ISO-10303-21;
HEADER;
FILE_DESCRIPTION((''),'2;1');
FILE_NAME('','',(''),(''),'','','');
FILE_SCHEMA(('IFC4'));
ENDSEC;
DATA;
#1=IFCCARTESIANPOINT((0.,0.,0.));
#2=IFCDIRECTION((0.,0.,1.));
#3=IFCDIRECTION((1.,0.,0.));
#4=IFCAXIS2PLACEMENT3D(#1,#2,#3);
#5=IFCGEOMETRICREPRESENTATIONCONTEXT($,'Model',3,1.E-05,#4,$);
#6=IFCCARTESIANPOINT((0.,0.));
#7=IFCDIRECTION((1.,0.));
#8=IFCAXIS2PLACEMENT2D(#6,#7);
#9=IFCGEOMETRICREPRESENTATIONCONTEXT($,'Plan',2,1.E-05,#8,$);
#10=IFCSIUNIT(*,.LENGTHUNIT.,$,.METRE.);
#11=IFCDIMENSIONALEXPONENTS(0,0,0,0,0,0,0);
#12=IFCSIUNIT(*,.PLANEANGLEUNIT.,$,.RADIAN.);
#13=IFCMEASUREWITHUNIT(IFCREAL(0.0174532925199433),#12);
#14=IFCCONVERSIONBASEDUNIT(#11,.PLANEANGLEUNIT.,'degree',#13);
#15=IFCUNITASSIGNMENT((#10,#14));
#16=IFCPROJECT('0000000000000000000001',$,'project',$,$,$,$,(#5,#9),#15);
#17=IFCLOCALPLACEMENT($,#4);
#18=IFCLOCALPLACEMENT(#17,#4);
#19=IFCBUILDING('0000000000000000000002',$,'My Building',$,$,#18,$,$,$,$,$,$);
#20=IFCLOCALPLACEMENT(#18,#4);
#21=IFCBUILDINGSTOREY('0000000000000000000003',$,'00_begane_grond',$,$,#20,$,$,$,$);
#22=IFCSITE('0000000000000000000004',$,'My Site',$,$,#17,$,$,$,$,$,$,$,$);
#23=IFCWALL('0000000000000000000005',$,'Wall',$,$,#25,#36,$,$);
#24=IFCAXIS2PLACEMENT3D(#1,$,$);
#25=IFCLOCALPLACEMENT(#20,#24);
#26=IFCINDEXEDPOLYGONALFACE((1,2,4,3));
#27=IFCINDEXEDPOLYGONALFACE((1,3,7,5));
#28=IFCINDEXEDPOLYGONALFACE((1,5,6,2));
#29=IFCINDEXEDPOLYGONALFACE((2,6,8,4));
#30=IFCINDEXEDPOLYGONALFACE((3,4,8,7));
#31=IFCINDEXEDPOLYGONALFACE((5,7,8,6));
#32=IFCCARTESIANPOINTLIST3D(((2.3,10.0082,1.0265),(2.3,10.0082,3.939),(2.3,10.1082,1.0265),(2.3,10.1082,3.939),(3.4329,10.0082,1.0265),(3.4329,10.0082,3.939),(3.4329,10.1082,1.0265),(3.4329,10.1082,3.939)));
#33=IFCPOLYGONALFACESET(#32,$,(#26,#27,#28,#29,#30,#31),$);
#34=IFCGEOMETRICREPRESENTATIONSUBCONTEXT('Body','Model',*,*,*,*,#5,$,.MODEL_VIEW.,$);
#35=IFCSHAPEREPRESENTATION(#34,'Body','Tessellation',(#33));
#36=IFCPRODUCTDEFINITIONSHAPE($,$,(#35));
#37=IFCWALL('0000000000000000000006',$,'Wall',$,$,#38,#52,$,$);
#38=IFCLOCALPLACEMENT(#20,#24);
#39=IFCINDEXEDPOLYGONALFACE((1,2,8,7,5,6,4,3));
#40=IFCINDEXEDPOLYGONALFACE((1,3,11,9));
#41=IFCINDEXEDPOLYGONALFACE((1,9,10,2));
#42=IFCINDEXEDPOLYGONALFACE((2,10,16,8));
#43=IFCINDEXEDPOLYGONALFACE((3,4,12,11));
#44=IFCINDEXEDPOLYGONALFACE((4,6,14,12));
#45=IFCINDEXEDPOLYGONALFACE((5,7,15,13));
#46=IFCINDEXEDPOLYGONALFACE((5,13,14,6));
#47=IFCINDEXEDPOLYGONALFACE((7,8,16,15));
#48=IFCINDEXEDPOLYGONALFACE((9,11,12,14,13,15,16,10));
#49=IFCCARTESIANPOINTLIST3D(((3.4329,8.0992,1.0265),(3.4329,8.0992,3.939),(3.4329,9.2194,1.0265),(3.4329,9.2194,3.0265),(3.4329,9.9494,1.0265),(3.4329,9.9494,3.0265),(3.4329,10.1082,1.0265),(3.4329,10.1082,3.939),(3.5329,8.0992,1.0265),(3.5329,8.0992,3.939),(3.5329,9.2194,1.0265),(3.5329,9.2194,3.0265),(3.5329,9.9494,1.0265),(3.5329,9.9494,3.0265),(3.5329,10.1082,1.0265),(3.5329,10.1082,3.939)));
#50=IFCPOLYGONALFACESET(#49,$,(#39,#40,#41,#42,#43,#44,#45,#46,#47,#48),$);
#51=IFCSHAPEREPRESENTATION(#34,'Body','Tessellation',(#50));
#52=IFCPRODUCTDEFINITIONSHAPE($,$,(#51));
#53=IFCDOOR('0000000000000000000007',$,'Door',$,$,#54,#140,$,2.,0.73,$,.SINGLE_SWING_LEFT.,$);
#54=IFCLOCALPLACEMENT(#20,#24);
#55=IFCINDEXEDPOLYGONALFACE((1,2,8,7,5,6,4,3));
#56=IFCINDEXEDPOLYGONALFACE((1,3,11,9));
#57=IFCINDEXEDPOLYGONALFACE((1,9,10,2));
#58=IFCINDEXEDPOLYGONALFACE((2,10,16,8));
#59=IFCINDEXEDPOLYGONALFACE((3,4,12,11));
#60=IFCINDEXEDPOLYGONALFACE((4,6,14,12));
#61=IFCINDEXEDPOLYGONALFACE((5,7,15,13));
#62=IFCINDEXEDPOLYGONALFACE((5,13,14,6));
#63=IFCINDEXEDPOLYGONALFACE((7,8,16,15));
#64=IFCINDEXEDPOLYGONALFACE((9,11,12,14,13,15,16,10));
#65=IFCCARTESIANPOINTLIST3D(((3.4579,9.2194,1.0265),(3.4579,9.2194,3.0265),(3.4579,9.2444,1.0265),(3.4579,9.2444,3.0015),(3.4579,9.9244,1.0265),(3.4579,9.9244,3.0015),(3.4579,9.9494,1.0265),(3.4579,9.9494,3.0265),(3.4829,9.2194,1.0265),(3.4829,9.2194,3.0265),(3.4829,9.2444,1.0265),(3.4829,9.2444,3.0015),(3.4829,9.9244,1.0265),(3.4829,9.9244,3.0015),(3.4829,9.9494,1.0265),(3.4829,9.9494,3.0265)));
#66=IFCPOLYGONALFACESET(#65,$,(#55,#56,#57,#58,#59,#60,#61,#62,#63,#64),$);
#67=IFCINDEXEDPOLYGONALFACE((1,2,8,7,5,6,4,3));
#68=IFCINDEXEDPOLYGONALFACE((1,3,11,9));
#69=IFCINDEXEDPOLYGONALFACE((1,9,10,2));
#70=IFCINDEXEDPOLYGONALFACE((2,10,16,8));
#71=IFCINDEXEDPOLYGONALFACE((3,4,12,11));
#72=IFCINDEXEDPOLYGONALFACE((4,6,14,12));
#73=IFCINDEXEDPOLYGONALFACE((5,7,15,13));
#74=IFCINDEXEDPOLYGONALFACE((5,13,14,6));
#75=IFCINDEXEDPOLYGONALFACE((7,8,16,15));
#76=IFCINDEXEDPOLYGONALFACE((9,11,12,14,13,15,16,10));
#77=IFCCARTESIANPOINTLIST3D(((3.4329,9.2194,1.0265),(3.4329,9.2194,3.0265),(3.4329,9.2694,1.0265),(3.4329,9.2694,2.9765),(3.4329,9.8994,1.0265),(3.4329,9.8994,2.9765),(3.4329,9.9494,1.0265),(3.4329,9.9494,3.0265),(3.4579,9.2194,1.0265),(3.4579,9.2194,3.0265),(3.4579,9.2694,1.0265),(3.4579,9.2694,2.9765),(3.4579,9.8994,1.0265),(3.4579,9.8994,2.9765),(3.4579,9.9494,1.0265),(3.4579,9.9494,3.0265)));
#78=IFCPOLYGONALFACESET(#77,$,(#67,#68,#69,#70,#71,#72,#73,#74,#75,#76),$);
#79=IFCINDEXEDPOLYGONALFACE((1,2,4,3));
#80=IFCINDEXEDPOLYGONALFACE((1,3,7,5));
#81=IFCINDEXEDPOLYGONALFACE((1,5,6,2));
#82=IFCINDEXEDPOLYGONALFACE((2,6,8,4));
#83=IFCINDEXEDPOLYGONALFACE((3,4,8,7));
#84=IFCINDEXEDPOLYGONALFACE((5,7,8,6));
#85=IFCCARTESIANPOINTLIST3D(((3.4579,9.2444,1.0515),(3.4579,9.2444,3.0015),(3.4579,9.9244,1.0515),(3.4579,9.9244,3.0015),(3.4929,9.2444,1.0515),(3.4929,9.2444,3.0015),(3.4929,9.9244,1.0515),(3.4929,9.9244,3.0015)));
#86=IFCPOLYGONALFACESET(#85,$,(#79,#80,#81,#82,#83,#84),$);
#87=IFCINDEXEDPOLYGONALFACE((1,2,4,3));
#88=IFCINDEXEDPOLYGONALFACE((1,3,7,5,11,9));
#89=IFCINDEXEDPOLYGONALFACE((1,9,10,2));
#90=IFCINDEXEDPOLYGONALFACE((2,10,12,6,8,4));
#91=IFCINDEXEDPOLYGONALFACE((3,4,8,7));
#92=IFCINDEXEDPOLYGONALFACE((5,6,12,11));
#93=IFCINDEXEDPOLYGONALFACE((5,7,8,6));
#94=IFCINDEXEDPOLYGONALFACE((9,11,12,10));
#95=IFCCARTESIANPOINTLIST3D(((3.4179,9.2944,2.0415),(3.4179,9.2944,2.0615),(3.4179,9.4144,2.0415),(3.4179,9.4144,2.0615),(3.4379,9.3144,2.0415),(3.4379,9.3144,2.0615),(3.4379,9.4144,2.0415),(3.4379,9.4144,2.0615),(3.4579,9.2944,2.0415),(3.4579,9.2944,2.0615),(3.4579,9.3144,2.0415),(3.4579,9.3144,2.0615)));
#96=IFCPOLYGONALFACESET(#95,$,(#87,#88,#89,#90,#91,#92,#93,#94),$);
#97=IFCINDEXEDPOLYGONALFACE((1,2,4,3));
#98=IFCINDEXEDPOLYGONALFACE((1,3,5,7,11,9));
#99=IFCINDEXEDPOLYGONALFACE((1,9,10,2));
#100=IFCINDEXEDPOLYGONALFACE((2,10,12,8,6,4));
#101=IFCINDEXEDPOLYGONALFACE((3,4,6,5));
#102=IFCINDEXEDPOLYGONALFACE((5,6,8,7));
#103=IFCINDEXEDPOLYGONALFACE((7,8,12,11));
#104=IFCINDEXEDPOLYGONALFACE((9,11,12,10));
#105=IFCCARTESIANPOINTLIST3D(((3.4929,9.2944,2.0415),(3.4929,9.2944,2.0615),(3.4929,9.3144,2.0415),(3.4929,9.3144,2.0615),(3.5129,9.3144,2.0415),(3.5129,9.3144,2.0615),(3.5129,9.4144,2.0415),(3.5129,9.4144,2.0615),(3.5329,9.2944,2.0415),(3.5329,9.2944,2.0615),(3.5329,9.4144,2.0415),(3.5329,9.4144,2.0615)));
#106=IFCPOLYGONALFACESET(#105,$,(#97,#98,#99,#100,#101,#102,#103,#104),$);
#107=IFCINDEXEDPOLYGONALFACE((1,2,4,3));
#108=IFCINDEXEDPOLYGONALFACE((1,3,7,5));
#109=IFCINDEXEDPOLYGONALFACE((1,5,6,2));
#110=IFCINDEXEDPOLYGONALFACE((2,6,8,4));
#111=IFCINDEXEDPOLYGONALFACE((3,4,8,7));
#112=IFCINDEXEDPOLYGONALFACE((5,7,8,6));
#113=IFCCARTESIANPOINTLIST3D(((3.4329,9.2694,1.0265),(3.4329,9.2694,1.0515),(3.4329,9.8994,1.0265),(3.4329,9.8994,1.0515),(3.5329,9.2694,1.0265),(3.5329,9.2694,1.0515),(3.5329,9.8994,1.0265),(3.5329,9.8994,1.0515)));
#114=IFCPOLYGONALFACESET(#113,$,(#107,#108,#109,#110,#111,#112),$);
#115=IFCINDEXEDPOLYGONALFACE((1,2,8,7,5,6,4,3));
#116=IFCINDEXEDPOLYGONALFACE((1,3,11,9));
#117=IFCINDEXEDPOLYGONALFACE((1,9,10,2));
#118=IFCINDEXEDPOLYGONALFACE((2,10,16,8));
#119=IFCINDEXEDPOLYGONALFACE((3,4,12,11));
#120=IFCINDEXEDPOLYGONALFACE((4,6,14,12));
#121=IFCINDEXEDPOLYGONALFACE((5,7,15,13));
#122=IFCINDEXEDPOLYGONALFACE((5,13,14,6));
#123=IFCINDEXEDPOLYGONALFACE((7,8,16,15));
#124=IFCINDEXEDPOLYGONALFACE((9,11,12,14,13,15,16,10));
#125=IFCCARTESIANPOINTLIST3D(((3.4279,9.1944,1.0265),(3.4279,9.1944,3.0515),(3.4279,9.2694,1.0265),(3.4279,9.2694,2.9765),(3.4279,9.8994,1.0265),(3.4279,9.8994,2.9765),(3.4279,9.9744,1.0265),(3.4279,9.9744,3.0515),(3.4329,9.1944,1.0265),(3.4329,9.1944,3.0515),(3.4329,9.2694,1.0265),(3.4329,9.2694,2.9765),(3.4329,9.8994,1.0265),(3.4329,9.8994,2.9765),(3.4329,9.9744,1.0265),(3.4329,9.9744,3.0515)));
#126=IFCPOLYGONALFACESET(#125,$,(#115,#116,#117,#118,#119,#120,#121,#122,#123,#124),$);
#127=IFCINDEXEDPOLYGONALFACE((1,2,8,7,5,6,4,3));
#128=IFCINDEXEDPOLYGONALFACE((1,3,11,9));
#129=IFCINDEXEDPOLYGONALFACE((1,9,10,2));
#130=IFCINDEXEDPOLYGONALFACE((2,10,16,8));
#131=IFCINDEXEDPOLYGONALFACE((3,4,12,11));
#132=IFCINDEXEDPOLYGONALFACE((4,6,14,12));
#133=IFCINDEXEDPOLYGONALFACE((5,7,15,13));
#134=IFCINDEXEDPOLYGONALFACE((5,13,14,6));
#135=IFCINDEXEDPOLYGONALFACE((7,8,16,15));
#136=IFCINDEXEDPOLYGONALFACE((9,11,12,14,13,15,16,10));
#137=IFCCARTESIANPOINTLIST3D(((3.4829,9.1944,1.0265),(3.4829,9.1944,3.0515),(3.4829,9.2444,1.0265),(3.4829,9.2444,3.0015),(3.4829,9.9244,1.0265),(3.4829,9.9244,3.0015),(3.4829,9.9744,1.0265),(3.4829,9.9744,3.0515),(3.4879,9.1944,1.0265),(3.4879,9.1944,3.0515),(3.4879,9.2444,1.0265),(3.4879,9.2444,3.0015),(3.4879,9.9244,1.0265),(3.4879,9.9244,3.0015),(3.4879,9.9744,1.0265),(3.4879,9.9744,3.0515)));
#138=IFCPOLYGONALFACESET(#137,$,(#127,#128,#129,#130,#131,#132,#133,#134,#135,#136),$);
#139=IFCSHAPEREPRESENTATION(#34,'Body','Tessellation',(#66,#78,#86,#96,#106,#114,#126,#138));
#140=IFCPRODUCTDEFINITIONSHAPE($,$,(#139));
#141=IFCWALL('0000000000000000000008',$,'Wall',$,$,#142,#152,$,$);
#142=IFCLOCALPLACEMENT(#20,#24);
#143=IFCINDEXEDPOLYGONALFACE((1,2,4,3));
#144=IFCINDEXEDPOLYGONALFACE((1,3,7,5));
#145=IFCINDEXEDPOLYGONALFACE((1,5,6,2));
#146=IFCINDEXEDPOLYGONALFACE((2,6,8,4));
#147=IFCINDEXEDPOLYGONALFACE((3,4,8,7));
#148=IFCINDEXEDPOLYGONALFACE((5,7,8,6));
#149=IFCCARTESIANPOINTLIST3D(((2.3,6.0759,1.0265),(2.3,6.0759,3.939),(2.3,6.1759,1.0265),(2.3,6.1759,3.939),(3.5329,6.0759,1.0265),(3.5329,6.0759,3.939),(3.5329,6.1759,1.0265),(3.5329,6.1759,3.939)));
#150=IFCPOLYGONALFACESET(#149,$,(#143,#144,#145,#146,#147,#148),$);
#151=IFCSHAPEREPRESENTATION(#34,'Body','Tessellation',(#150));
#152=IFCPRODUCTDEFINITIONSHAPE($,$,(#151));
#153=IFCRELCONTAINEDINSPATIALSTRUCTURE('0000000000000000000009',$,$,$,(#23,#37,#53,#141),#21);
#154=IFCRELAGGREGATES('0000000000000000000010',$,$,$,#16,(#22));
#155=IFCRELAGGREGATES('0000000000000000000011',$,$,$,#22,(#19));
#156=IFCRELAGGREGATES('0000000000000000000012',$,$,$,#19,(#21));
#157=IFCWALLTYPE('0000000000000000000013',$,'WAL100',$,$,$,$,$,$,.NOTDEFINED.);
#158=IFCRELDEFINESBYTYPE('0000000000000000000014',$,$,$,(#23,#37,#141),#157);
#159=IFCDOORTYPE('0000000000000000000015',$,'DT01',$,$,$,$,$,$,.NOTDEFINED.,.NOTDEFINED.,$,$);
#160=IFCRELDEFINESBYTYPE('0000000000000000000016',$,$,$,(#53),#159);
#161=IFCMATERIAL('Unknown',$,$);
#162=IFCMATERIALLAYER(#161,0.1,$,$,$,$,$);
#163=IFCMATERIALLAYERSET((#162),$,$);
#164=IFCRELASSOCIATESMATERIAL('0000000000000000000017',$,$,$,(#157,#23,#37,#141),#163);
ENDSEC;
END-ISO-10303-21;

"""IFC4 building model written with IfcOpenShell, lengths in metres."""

from ifc_helpers import new_model, entity, si_unit, converted_unit, frame, origin_with_axes, origin_2d_with_axis, place, context, subcontext, project, spatial, line, indexed_curve, outline, extrude, shape, source, transform, mapped, material, layer, layer_set, layer_usage, type_object, type_shapes, element, fill, save


model = new_model("IFC4")

# Units and contexts
model_context = context("Model", 3, precision=1e-05, world=origin_with_axes())
plan_context = context("Plan", 2, precision=1e-05, world=origin_2d_with_axis())
body_context_1 = subcontext(model_context, "Body", "Model", "MODEL_VIEW")
body_context_2 = subcontext(plan_context, "Body", "Plan", "PLAN_VIEW")
ifc_project = project(units=[si_unit("LENGTHUNIT", "METRE"), converted_unit("PLANEANGLEUNIT", "degree", entity("IfcReal", 0.0174532925199433), si_unit("PLANEANGLEUNIT", "RADIAN"), dimensions=[0, 0, 0, 0, 0, 0, 0])], contexts=[model_context, plan_context])

# Site, building, storey
site_placement = place(None, origin_with_axes())
site = spatial("IfcSite", under=ifc_project, at=site_placement, Name="My Site")
building_placement = place(site_placement, origin_with_axes())
building = spatial("IfcBuilding", under=site, at=building_placement, Name="My Building")
storey_placement = place(building_placement, origin_with_axes())
storey = spatial("IfcBuildingStorey", under=building, at=storey_placement, Name="00_begane_grond")

# Shared definitions
ifc_material = material(Name="Unknown")

# Shared definitions
ifc_layer_1 = layer(ifc_material, 0.1)
ifc_layer_set_1 = layer_set([ifc_layer_1])
wall_type_1 = type_object("IfcWallType", Name="WAL100", PredefinedType="NOTDEFINED", material=ifc_layer_set_1)

# Shared definitions
shared_shape_1 = source(origin_with_axes(), body_context_1, "Body", "SweptSolid", [
    extrude(outline(indexed_curve([(0.0, 0.0), (0.73, 0.0), (0.73, 2.0), (0.0, 2.0)], segments=[line(1, 2, 3, 4, 1)])), frame((0.0, -0.1, 0.0), z_axis=(0.0, -1.0, 0.0), x_axis=(1.0, 0.0, 0.0)), (0.0, 0.0, -1.0), 0.3),
])
door_type_1 = type_object("IfcDoorType", Name="DT01", OperationType="NOTDEFINED", PredefinedType="NOTDEFINED")
shared_shape_2 = source(origin_with_axes(), body_context_1, "Body", "SweptSolid", [
    extrude(outline(indexed_curve([(0.0, 0.0), (0.0, 2.0), (0.73, 2.0), (0.73, 0.0), (0.705, 0.0), (0.705, 1.975), (0.025, 1.975), (0.025, 0.0)], segments=[line(1, 2, 3, 4, 5, 6, 7, 8, 1)])), frame((0.0, 0.025, 0.0), z_axis=(0.0, -1.0, 0.0), x_axis=(1.0, 0.0, 0.0)), (0.0, 0.0, -1.0), 0.025),
    extrude(outline(indexed_curve([(0.0, 0.0), (0.0, 2.0), (0.73, 2.0), (0.73, 0.0), (0.68, 0.0), (0.68, 1.95), (0.05, 1.95), (0.05, 0.0)], segments=[line(1, 2, 3, 4, 5, 6, 7, 8, 1)])), frame((0.0, 0.0, 0.0), z_axis=(0.0, -1.0, 0.0), x_axis=(1.0, 0.0, 0.0)), (0.0, 0.0, -1.0), 0.025),
    extrude(outline(indexed_curve([(0.0, 0.0), (0.68, 0.0), (0.68, 0.035), (0.0, 0.035)], segments=[line(1, 2, 3, 4, 1)])), frame((0.025, 0.025, 0.025), z_axis=(0.0, 0.0, 1.0), x_axis=(1.0, 0.0, 0.0)), (0.0, 0.0, 1.0), 1.95),
    extrude(outline(indexed_curve([(0.0, 0.0), (0.0, -0.04), (-0.12, -0.04), (-0.12, -0.02), (-0.02, -0.02), (-0.02, 0.0)], segments=[line(1, 2, 3, 4, 5, 6, 1)])), frame((0.655, 0.025, 1.015), z_axis=(0.0, 0.0, 1.0), x_axis=(1.0, 0.0, 0.0)), (0.0, 0.0, 1.0), 0.02),
    extrude(outline(indexed_curve([(0.0, 0.0), (0.0, 0.04), (-0.12, 0.04), (-0.12, 0.02), (-0.02, 0.02), (-0.02, 0.0)], segments=[line(1, 2, 3, 4, 5, 6, 1)])), frame((0.655, 0.06, 1.015), z_axis=(0.0, 0.0, 1.0), x_axis=(1.0, 0.0, 0.0)), (0.0, 0.0, 1.0), 0.02),
    extrude(outline(indexed_curve([(0.0, 0.0), (0.63, 0.0), (0.63, 0.1), (0.0, 0.1)], segments=[line(1, 2, 3, 4, 1)])), frame((0.05, 0.0, 0.0), z_axis=(0.0, 0.0, 1.0), x_axis=(1.0, 0.0, 0.0)), (0.0, 0.0, 1.0), 0.025),
    extrude(outline(indexed_curve([(0.0, 0.0), (0.0, 2.025), (0.78, 2.025), (0.78, 0.0), (0.705, 0.0), (0.705, 1.95), (0.075, 1.95), (0.075, 0.0)], segments=[line(1, 2, 3, 4, 5, 6, 7, 8, 1)])), frame((-0.025, -0.005, 0.0), z_axis=(0.0, -1.0, 0.0), x_axis=(1.0, 0.0, 0.0)), (0.0, 0.0, -1.0), 0.005),
    extrude(outline(indexed_curve([(0.0, 0.0), (0.0, 2.025), (0.78, 2.025), (0.78, 0.0), (0.73, 0.0), (0.73, 1.975), (0.05, 1.975), (0.05, 0.0)], segments=[line(1, 2, 3, 4, 5, 6, 7, 8, 1)])), frame((-0.025, 0.05, 0.0), z_axis=(0.0, -1.0, 0.0), x_axis=(1.0, 0.0, 0.0)), (0.0, 0.0, -1.0), 0.005),
])
shared_shape_3 = source(origin_with_axes(), body_context_2, "Body", "Curve2D", [
    entity("IfcIndexedPolyCurve", entity("IfcCartesianPointList2D", [[0.0, 0.0], [0.0, 0.05], [0.025, 0.05], [0.025, 0.025], [0.05, 0.025], [0.05, 0.0]]), [entity("IfcLineIndex", [1, 2, 3, 4, 5, 6, 1])]),
    entity("IfcIndexedPolyCurve", entity("IfcCartesianPointList2D", [[0.73, 0.0], [0.73, 0.05], [0.705, 0.05], [0.705, 0.025], [0.68, 0.025], [0.68, 0.0]]), [entity("IfcLineIndex", [1, 2, 3, 4, 5, 6, 1])]),
    entity("IfcTrimmedCurve", entity("IfcEllipse", entity("IfcAxis2Placement2D", entity("IfcCartesianPoint", [0.06, 0.05]), entity("IfcDirection", [1.0, 0.0])), 0.645, 0.68), [entity("IfcCartesianPoint", [0.705, 0.05])], [entity("IfcCartesianPoint", [0.06, 0.73])], True, "CARTESIAN"),
    entity("IfcIndexedPolyCurve", entity("IfcCartesianPointList2D", [[0.025, 0.05], [0.06, 0.05], [0.06, 0.73], [0.025, 0.73]]), [entity("IfcLineIndex", [1, 2, 3, 4, 1])]),
])
type_shapes(door_type_1, [shared_shape_2, shared_shape_3])

# Wall
ifc_layer_usage_1 = layer_usage(ifc_layer_set_1, "AXIS2", "POSITIVE", 0.0)
wall_1_placement = place(storey_placement, frame((2.3, 10.0082, 1.0265), z_axis=(0.0, 0.0, 1.0), x_axis=(1.0, -0.000001, 0.0)))
element("IfcWall", 1, at=wall_1_placement, inside=storey, type_object=wall_type_1, material=ifc_layer_usage_1, Name="Wall", context=body_context_1, shape_type="SweptSolid", body=[
    extrude(outline(indexed_curve([(0.0, 0.0), (0.0, 0.1), (1.1329, 0.1), (1.1329, 0.0), (0.0, 0.0)], self_intersect=False)), origin_with_axes(), (0.0, 0.0, 1.0), 2.9125),
])

# Wall, opening, door
ifc_layer_usage_2 = layer_usage(ifc_layer_set_1, "AXIS2", "POSITIVE", 0.0)
wall_2_placement = place(storey_placement, frame((3.5329, 8.0992, 1.0265), z_axis=(0.0, 0.0, 1.0), x_axis=(0.000001, 1.0, 0.0)))
wall_2 = element("IfcWall", 2, at=wall_2_placement, inside=storey, type_object=wall_type_1, material=ifc_layer_usage_2, Name="Wall", context=body_context_1, shape_type="SweptSolid", body=[
    extrude(outline(indexed_curve([(0.0, 0.0), (0.0, 0.1), (2.009, 0.1), (2.009, 0.0), (0.0, 0.0)], self_intersect=False)), origin_with_axes(), (0.0, 0.0, 1.0), 2.9125),
])
opening_1_placement = place(wall_2_placement, frame((1.8502, 0.1, 0.0), z_axis=(0.0, 0.0, 1.0), x_axis=(-1.0, 0.0, 0.0)))
opening_1 = element("IfcOpeningElement", 3, at=opening_1_placement, cuts=wall_2, PredefinedType="OPENING", context=body_context_1, shape_type="MappedRepresentation", body=[
    mapped(shared_shape_1, transform((0.0, 0.0, 0.0), x_axis=(1.0, 0.0, 0.0), y_axis=(0.0, 1.0, 0.0), z_axis=(0.0, 0.0, 1.0), scale=1.0)),
])
door_1_placement = place(opening_1_placement, frame((0.0, 0.0, 0.0), z_axis=(0.0, 0.0, 1.0), x_axis=(1.0, 0.0, 0.0)))
door_1 = element("IfcDoor", 4, at=door_1_placement, inside=storey, type_object=door_type_1, Name="Door", OperationType="SINGLE_SWING_LEFT", OverallHeight=2.0, OverallWidth=0.73, shapes=[
    shape(body_context_1, "Body", "MappedRepresentation", [mapped(shared_shape_2, transform((0.0, 0.0, 0.0), x_axis=(1.0, 0.0, 0.0), y_axis=(0.0, 1.0, 0.0), z_axis=(0.0, 0.0, 1.0), scale=1.0))]),
    shape(body_context_2, "Body", "MappedRepresentation", [mapped(shared_shape_3, transform((0.0, 0.0, 0.0), x_axis=(1.0, 0.0, 0.0), y_axis=(0.0, 1.0, 0.0), z_axis=(0.0, 0.0, 1.0), scale=1.0))]),
])
fill(opening_1, door_1)

# Wall
ifc_layer_usage_3 = layer_usage(ifc_layer_set_1, "AXIS2", "POSITIVE", 0.0)
wall_3_placement = place(storey_placement, frame((2.3, 6.0759, 1.0265), z_axis=(0.0, 0.0, 1.0), x_axis=(1.0, -0.000001, 0.0)))
element("IfcWall", 5, at=wall_3_placement, inside=storey, type_object=wall_type_1, material=ifc_layer_usage_3, Name="Wall", context=body_context_1, shape_type="SweptSolid", body=[
    extrude(outline(indexed_curve([(0.0, 0.0), (0.0, 0.1), (1.2329, 0.1), (1.2329, 0.0), (0.0, 0.0)], self_intersect=False)), origin_with_axes(), (0.0, 0.0, 1.0), 2.9125),
])

save(model, "model.ifc")
